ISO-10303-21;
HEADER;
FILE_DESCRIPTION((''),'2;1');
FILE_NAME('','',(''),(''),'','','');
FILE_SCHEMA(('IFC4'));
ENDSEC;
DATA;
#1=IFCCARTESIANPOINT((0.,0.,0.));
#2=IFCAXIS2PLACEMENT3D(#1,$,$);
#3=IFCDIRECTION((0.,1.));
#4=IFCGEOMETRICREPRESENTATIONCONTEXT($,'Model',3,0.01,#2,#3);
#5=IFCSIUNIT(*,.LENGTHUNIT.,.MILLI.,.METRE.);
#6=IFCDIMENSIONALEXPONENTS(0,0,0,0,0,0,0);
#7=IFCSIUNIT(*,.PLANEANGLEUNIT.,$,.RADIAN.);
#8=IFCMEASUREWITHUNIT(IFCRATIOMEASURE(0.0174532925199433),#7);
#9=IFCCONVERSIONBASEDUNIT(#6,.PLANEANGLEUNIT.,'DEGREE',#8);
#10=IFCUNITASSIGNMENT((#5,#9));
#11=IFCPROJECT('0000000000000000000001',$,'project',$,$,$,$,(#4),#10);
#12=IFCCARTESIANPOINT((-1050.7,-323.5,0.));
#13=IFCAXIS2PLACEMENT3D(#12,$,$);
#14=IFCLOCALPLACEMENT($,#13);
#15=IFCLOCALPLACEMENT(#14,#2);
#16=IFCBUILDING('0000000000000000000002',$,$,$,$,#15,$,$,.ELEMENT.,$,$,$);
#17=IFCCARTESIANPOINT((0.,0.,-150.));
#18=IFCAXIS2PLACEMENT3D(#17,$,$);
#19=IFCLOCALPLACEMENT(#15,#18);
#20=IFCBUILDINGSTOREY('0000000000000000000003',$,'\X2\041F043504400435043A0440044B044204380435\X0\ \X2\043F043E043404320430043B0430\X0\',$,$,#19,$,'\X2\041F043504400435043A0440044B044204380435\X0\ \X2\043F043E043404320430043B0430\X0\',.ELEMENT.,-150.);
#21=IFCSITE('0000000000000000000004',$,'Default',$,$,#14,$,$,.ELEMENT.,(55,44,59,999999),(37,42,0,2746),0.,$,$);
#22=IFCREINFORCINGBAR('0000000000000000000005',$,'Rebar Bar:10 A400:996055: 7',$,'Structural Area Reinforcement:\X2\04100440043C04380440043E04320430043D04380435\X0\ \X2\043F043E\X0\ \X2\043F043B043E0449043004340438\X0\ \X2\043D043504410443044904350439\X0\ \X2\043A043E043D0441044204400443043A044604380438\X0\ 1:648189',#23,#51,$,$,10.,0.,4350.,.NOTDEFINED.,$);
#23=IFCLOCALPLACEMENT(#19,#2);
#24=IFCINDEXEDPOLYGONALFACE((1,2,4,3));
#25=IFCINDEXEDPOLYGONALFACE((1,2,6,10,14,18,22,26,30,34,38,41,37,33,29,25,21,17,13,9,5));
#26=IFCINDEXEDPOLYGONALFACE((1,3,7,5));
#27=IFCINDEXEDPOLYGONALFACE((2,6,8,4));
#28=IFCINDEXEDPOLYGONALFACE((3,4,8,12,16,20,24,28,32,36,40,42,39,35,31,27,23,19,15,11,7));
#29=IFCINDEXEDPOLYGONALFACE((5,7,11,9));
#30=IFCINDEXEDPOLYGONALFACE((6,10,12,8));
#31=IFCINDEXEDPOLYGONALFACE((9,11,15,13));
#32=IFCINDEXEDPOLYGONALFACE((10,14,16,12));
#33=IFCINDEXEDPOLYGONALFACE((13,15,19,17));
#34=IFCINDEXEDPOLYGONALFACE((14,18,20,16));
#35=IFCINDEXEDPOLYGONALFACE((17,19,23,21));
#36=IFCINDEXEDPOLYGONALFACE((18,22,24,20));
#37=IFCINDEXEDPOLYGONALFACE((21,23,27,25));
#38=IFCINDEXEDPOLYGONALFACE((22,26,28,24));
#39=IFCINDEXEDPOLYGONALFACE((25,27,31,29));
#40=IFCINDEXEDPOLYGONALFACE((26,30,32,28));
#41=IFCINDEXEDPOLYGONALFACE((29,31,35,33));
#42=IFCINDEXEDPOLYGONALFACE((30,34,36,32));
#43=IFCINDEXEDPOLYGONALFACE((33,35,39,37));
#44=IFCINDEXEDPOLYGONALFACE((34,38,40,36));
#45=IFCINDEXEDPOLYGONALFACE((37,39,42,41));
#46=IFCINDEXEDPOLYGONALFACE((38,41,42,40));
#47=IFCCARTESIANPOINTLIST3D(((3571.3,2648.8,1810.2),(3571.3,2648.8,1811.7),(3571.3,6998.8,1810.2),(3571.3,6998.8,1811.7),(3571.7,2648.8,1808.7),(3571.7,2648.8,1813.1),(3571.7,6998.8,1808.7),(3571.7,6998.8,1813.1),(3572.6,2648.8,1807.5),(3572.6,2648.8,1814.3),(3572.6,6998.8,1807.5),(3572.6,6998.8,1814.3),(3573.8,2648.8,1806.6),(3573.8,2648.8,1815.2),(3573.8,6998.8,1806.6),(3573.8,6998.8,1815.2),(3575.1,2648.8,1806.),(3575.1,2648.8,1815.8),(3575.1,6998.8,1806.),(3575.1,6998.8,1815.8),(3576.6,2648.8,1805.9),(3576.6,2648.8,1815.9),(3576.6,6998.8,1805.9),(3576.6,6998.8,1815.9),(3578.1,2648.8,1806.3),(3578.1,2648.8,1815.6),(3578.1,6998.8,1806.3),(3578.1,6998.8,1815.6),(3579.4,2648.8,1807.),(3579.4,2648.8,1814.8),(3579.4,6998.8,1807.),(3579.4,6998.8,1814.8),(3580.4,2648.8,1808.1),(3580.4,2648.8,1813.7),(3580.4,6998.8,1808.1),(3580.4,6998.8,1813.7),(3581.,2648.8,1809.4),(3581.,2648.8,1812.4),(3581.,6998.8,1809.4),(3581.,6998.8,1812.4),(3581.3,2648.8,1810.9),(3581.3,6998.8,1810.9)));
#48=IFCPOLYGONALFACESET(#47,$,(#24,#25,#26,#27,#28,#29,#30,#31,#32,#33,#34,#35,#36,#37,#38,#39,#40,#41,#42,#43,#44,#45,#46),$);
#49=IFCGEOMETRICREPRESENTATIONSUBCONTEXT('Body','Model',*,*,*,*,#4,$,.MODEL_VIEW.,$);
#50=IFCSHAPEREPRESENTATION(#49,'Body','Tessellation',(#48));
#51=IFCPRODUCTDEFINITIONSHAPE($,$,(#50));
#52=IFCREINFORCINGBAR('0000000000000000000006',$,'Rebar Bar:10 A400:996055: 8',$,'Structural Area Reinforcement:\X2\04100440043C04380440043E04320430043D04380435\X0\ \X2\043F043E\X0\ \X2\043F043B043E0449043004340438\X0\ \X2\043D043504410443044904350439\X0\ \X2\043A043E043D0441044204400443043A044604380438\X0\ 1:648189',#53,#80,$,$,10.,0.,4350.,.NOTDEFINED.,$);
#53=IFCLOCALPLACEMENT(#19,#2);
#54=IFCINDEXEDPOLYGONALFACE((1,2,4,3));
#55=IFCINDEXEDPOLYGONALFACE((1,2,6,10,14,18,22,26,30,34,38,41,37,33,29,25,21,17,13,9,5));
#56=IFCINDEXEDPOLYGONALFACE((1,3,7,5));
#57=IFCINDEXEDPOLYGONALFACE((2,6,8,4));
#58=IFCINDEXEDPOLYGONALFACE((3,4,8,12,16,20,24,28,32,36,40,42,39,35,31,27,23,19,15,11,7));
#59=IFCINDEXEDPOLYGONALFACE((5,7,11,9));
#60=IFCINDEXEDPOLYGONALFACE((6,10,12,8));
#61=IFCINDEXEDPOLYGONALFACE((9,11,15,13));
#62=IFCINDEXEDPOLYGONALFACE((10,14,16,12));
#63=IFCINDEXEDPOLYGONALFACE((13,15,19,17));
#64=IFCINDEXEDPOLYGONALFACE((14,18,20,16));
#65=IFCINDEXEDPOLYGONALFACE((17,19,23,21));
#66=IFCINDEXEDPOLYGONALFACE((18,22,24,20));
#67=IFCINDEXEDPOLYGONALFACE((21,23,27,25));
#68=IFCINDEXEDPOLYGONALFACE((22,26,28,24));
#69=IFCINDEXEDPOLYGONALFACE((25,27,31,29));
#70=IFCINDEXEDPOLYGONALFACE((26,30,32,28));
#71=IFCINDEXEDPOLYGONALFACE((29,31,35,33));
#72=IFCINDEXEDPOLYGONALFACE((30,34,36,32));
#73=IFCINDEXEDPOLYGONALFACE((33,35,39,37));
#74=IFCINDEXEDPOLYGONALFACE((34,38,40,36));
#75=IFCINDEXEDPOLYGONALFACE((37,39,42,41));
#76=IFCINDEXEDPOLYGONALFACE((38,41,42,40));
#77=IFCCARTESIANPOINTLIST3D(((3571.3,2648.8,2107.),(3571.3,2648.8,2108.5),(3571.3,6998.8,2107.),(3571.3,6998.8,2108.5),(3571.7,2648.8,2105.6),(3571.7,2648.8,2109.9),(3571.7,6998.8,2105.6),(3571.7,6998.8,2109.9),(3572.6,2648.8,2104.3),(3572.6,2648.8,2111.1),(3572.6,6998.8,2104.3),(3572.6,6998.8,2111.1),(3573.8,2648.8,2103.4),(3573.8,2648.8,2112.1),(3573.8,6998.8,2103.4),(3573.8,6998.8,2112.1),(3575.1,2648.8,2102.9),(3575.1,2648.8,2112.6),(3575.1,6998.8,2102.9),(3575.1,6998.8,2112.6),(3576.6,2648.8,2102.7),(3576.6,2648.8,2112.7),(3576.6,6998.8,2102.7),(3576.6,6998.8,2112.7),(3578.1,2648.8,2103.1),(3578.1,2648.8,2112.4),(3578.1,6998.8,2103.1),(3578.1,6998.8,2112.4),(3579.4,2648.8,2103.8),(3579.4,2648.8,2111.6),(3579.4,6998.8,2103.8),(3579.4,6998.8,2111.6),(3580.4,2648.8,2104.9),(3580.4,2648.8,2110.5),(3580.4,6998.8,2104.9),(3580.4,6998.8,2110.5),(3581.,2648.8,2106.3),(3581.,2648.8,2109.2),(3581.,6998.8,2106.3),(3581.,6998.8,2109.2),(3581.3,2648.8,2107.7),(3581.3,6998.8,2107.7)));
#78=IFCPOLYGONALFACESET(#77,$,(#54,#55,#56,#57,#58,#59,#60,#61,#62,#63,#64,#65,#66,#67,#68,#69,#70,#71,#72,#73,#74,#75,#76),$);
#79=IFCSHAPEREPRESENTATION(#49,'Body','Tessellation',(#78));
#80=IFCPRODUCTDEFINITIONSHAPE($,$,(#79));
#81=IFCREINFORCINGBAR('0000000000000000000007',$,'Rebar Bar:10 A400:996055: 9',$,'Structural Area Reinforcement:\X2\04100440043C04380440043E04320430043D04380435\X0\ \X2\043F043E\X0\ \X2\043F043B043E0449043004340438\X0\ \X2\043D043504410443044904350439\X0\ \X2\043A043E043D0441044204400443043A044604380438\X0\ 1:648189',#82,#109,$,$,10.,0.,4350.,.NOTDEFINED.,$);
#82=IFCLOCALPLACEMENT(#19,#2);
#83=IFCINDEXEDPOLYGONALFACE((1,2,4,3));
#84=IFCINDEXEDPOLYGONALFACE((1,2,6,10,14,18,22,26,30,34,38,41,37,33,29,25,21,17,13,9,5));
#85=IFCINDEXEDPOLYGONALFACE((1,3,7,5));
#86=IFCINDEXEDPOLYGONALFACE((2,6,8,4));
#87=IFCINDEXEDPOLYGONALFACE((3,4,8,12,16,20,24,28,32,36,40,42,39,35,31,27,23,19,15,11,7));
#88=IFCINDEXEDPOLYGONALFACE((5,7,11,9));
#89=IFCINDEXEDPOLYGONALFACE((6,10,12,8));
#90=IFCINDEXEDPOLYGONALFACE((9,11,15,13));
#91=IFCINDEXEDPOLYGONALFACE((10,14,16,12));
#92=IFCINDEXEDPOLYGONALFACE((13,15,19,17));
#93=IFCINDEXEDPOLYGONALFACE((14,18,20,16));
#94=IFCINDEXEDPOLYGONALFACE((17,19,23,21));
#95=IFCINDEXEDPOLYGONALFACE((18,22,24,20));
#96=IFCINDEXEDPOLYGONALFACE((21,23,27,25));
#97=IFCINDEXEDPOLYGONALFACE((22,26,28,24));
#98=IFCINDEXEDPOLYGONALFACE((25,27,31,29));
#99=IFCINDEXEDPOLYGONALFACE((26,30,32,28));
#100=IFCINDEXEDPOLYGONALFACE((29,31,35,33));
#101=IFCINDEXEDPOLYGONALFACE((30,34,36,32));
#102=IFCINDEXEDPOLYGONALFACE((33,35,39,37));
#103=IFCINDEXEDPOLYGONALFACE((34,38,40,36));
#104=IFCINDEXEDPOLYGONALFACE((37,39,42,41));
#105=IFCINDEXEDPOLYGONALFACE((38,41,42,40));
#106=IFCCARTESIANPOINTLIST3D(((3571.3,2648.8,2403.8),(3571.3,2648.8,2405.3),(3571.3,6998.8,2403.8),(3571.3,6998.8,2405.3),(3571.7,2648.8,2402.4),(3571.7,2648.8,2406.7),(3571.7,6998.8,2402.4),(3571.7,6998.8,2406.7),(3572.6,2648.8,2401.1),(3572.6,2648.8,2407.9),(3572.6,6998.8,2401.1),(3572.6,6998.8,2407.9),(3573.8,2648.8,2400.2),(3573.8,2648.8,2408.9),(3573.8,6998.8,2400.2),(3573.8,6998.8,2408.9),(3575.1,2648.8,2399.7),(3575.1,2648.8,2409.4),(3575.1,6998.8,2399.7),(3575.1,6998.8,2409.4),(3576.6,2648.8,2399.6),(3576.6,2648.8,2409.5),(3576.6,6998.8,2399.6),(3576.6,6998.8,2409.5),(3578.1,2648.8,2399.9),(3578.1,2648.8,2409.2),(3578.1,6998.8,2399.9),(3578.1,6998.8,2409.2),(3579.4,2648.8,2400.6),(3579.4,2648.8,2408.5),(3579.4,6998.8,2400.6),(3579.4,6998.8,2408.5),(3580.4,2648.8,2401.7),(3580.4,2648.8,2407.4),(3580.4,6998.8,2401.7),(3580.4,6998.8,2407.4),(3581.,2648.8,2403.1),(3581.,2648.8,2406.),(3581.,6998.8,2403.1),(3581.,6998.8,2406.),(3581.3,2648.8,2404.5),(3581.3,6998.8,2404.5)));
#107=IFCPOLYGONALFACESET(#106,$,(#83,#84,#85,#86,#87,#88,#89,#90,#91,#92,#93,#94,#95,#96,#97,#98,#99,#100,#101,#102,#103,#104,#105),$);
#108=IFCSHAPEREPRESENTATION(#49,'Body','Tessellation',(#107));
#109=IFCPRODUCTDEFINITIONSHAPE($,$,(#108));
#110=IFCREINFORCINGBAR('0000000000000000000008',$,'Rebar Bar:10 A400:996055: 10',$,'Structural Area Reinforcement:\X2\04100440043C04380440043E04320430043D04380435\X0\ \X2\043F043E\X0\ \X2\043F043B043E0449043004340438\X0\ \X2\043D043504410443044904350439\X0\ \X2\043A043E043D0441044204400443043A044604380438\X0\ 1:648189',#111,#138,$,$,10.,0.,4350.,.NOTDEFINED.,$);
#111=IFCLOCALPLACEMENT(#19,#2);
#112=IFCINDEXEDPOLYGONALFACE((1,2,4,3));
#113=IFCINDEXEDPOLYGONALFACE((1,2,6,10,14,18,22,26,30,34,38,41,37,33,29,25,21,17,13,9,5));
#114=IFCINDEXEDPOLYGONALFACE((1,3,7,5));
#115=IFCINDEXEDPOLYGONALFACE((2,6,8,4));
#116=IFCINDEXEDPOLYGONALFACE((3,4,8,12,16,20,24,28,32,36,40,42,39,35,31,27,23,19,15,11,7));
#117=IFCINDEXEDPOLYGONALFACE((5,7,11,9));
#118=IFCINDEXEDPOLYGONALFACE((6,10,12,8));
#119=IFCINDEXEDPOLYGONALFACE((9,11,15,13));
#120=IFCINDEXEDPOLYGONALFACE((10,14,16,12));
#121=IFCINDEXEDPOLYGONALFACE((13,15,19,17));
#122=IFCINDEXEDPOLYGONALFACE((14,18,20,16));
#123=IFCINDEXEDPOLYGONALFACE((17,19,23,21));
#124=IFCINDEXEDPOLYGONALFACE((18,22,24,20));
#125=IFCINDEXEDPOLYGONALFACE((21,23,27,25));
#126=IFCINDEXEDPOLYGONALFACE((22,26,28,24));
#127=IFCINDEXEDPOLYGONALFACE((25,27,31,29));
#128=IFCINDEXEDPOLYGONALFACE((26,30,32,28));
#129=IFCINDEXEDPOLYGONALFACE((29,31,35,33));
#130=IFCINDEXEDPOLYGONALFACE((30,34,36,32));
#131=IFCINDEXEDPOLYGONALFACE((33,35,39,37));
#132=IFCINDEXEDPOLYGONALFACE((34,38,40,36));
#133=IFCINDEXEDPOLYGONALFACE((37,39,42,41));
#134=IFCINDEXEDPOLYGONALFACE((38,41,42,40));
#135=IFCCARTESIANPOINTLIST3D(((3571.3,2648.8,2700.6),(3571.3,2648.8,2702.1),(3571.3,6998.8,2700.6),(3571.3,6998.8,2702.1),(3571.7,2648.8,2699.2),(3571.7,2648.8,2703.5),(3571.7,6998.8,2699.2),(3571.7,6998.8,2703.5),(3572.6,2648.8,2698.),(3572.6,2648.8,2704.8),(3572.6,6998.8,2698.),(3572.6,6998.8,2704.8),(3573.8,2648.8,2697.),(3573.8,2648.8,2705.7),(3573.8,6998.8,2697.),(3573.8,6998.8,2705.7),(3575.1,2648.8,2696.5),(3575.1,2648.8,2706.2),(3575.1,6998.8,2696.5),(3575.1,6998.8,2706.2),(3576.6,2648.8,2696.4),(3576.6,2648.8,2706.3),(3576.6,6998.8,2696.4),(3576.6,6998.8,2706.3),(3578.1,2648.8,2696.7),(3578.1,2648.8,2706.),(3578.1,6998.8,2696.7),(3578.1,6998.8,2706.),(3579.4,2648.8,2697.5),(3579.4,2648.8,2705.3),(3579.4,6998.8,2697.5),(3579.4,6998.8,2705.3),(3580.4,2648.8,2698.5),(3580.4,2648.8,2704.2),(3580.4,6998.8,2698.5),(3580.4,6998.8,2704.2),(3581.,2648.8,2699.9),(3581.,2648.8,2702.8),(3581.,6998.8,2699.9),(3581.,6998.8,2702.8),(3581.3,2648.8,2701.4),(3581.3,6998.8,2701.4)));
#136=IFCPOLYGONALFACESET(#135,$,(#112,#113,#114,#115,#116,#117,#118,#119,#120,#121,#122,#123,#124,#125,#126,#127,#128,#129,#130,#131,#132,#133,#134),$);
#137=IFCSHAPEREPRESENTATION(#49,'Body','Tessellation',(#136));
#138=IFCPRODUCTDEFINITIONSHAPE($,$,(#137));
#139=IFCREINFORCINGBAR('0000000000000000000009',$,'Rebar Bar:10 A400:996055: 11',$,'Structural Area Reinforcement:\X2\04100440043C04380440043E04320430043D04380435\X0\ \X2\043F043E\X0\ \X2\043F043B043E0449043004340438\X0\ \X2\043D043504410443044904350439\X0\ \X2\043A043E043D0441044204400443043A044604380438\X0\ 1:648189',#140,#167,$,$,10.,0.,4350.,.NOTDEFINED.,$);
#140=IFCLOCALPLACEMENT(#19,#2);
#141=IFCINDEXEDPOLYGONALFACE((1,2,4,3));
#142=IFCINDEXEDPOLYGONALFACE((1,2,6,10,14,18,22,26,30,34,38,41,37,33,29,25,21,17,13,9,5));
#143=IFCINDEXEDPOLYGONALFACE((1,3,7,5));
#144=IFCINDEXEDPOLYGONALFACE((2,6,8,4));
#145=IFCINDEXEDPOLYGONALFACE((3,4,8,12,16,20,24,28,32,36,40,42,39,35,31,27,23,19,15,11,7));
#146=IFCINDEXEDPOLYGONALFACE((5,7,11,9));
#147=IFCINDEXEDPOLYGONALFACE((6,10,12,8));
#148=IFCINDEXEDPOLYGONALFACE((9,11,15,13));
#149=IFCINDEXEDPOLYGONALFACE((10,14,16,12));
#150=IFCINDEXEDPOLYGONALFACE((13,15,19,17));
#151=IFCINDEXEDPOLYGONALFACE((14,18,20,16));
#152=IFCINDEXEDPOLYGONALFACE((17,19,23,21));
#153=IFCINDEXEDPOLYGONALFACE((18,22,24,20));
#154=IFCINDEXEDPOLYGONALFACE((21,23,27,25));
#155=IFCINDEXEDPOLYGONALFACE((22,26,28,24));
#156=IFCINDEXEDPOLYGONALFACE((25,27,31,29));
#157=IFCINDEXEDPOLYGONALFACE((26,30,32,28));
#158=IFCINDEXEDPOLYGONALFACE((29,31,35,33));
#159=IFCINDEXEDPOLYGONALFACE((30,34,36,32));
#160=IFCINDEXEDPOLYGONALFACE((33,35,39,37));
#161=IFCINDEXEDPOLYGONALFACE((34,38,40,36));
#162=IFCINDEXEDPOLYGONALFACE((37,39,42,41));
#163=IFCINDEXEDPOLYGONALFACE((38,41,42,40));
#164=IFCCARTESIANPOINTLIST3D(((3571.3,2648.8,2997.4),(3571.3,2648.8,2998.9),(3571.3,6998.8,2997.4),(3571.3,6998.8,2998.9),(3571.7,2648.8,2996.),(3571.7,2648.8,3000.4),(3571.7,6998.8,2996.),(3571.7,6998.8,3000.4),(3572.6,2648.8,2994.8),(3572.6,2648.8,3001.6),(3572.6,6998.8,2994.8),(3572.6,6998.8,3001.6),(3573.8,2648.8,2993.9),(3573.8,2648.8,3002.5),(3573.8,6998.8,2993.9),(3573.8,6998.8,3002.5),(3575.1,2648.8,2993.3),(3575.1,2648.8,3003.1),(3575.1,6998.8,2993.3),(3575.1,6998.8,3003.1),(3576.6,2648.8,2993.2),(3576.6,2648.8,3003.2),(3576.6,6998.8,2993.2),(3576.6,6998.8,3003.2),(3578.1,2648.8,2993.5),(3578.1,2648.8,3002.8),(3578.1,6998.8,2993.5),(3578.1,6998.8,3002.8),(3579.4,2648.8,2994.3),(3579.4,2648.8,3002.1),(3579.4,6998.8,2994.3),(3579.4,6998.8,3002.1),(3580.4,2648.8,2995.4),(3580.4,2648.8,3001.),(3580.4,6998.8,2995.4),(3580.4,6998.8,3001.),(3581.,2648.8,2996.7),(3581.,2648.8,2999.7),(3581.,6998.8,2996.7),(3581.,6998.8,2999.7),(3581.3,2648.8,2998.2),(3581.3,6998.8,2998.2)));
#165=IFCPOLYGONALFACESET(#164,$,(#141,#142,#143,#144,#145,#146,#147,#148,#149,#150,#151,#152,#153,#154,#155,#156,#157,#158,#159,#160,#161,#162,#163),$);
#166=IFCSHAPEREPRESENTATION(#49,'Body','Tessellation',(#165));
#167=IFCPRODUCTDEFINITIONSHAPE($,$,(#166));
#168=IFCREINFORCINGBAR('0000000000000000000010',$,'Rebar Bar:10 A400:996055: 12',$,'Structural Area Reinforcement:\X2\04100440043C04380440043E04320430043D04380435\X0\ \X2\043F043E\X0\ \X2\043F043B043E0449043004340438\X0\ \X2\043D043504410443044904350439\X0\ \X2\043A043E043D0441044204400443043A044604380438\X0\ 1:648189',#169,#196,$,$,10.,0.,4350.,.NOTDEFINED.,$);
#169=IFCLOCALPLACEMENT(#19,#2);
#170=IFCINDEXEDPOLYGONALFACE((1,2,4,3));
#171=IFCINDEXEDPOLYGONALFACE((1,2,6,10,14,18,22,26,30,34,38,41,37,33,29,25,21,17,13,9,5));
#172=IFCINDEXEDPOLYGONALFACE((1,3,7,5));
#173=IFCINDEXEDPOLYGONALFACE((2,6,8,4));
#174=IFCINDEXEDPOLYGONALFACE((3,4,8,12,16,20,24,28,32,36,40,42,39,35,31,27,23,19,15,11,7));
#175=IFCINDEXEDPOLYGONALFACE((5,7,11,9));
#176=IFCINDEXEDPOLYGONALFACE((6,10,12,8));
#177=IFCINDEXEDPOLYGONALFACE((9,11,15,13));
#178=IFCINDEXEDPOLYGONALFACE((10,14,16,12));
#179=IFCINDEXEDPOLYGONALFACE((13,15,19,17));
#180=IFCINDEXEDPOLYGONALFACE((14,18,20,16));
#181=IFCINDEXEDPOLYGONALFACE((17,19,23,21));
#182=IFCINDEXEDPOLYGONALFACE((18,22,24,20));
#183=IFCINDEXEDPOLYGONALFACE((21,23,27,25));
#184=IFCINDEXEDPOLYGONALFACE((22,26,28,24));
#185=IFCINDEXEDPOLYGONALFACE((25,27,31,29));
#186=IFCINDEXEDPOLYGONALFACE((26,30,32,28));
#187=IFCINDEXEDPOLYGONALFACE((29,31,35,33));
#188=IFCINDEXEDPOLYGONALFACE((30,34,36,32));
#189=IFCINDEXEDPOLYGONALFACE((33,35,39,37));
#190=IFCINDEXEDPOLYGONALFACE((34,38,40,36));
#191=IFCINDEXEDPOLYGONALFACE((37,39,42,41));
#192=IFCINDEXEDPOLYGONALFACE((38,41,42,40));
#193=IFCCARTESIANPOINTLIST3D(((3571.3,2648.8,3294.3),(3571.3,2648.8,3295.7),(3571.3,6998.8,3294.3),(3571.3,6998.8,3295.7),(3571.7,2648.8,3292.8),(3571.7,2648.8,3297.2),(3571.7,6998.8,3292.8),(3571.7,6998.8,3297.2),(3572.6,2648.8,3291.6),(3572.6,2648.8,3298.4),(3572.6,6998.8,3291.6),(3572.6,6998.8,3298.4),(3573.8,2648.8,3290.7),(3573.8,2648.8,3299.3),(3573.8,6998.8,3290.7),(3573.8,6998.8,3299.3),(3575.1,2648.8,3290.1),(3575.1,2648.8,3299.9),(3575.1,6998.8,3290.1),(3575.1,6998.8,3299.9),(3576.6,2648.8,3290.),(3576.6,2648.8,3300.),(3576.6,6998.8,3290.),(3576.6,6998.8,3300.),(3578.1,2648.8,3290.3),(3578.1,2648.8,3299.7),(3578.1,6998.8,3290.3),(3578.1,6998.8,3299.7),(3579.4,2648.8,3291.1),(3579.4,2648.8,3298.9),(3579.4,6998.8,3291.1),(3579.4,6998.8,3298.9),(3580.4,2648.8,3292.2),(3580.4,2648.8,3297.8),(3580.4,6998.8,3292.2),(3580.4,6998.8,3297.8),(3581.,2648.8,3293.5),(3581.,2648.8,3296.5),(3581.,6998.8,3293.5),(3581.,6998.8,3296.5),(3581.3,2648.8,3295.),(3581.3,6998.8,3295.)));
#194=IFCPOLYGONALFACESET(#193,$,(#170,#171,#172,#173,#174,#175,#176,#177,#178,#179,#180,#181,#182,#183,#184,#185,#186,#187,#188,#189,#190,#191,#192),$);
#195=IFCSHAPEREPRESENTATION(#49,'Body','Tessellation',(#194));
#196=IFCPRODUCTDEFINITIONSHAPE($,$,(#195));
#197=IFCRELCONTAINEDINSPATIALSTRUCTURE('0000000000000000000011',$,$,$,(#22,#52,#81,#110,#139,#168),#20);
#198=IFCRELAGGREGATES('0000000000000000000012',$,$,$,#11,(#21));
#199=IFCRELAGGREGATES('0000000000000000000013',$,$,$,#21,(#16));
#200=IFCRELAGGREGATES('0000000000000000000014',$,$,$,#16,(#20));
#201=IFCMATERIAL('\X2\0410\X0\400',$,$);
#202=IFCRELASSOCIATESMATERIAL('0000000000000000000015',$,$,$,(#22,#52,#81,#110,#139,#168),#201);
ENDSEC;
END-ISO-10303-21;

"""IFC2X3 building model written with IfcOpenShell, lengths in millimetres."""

from ifc_helpers import new_model, entity, si_unit, converted_unit, direction, frame, origin, place, context, subcontext, project, spatial, material, element, save


model = new_model("IFC2X3")

# Units and contexts
model_context = context("Model", 3, precision=0.01, world=origin(), true_north=direction((0.0, 1.0)))
body_context = subcontext(model_context, "Body", "Model", "MODEL_VIEW")
ifc_project = project(units=[si_unit("LENGTHUNIT", "METRE", prefix="MILLI"), converted_unit("PLANEANGLEUNIT", "DEGREE", entity("IfcRatioMeasure", 0.0174532925199433), si_unit("PLANEANGLEUNIT", "RADIAN"), dimensions=[0, 0, 0, 0, 0, 0, 0])], contexts=[model_context])

# Site, building, storey
site_placement = place(None, frame((-1050.7, -323.5, 0.0)))
site = spatial("IfcSite", under=ifc_project, at=site_placement, Name="Default", CompositionType="ELEMENT", RefLatitude=(55, 44, 59, 999999), RefLongitude=(37, 42, 0, 2746), RefElevation=0.0)
building_placement = place(site_placement, origin())
building = spatial("IfcBuilding", under=site, at=building_placement, CompositionType="ELEMENT")
storey_placement = place(building_placement, frame((0.0, 0.0, -150.0)))
storey = spatial("IfcBuildingStorey", under=building, at=storey_placement, Name="Перекрытие подвала", LongName="Перекрытие подвала", CompositionType="ELEMENT", Elevation=-150.0)

# Reinforcing bars
ifc_material = material(Name="А400")
reinforcing_bar_1_placement = place(storey_placement, origin())
element("IfcReinforcingBar", 1, at=reinforcing_bar_1_placement, inside=storey, material=ifc_material, Name="Rebar Bar:10 A400:996055: 7", ObjectType="Structural Area Reinforcement:Армирование по площади несущей конструкции 1:648189", BarLength=4350.0, BarRole="NOTDEFINED", CrossSectionArea=0.0, NominalDiameter=10.0, context=body_context, shape_type="AdvancedSweptSolid", body=[
    entity("IfcSweptDiskSolid", entity("IfcCompositeCurve", [entity("IfcCompositeCurveSegment", "CONTINUOUS", True, entity("IfcPolyline", [entity("IfcCartesianPoint", [3576.3, 2648.8, 1810.9]), entity("IfcCartesianPoint", [3576.3, 6998.8, 1810.9])]))], False), 5.0, None, 0.0, 1.0),
])
reinforcing_bar_2_placement = place(storey_placement, origin())
element("IfcReinforcingBar", 2, at=reinforcing_bar_2_placement, inside=storey, material=ifc_material, Name="Rebar Bar:10 A400:996055: 8", ObjectType="Structural Area Reinforcement:Армирование по площади несущей конструкции 1:648189", BarLength=4350.0, BarRole="NOTDEFINED", CrossSectionArea=0.0, NominalDiameter=10.0, context=body_context, shape_type="AdvancedSweptSolid", body=[
    entity("IfcSweptDiskSolid", entity("IfcCompositeCurve", [entity("IfcCompositeCurveSegment", "CONTINUOUS", True, entity("IfcPolyline", [entity("IfcCartesianPoint", [3576.3, 2648.8, 2107.7]), entity("IfcCartesianPoint", [3576.3, 6998.8, 2107.7])]))], False), 5.0, None, 0.0, 1.0),
])
reinforcing_bar_3_placement = place(storey_placement, origin())
element("IfcReinforcingBar", 3, at=reinforcing_bar_3_placement, inside=storey, material=ifc_material, Name="Rebar Bar:10 A400:996055: 9", ObjectType="Structural Area Reinforcement:Армирование по площади несущей конструкции 1:648189", BarLength=4350.0, BarRole="NOTDEFINED", CrossSectionArea=0.0, NominalDiameter=10.0, context=body_context, shape_type="AdvancedSweptSolid", body=[
    entity("IfcSweptDiskSolid", entity("IfcCompositeCurve", [entity("IfcCompositeCurveSegment", "CONTINUOUS", True, entity("IfcPolyline", [entity("IfcCartesianPoint", [3576.3, 2648.8, 2404.5]), entity("IfcCartesianPoint", [3576.3, 6998.8, 2404.5])]))], False), 5.0, None, 0.0, 1.0),
])
reinforcing_bar_4_placement = place(storey_placement, origin())
element("IfcReinforcingBar", 4, at=reinforcing_bar_4_placement, inside=storey, material=ifc_material, Name="Rebar Bar:10 A400:996055: 10", ObjectType="Structural Area Reinforcement:Армирование по площади несущей конструкции 1:648189", BarLength=4350.0, BarRole="NOTDEFINED", CrossSectionArea=0.0, NominalDiameter=10.0, context=body_context, shape_type="AdvancedSweptSolid", body=[
    entity("IfcSweptDiskSolid", entity("IfcCompositeCurve", [entity("IfcCompositeCurveSegment", "CONTINUOUS", True, entity("IfcPolyline", [entity("IfcCartesianPoint", [3576.3, 2648.8, 2701.4]), entity("IfcCartesianPoint", [3576.3, 6998.8, 2701.4])]))], False), 5.0, None, 0.0, 1.0),
])
reinforcing_bar_5_placement = place(storey_placement, origin())
element("IfcReinforcingBar", 5, at=reinforcing_bar_5_placement, inside=storey, material=ifc_material, Name="Rebar Bar:10 A400:996055: 11", ObjectType="Structural Area Reinforcement:Армирование по площади несущей конструкции 1:648189", BarLength=4350.0, BarRole="NOTDEFINED", CrossSectionArea=0.0, NominalDiameter=10.0, context=body_context, shape_type="AdvancedSweptSolid", body=[
    entity("IfcSweptDiskSolid", entity("IfcCompositeCurve", [entity("IfcCompositeCurveSegment", "CONTINUOUS", True, entity("IfcPolyline", [entity("IfcCartesianPoint", [3576.3, 2648.8, 2998.2]), entity("IfcCartesianPoint", [3576.3, 6998.8, 2998.2])]))], False), 5.0, None, 0.0, 1.0),
])
reinforcing_bar_6_placement = place(storey_placement, origin())
element("IfcReinforcingBar", 6, at=reinforcing_bar_6_placement, inside=storey, material=ifc_material, Name="Rebar Bar:10 A400:996055: 12", ObjectType="Structural Area Reinforcement:Армирование по площади несущей конструкции 1:648189", BarLength=4350.0, BarRole="NOTDEFINED", CrossSectionArea=0.0, NominalDiameter=10.0, context=body_context, shape_type="AdvancedSweptSolid", body=[
    entity("IfcSweptDiskSolid", entity("IfcCompositeCurve", [entity("IfcCompositeCurveSegment", "CONTINUOUS", True, entity("IfcPolyline", [entity("IfcCartesianPoint", [3576.3, 2648.8, 3295.0]), entity("IfcCartesianPoint", [3576.3, 6998.8, 3295.0])]))], False), 5.0, None, 0.0, 1.0),
])

save(model, "model.ifc")
